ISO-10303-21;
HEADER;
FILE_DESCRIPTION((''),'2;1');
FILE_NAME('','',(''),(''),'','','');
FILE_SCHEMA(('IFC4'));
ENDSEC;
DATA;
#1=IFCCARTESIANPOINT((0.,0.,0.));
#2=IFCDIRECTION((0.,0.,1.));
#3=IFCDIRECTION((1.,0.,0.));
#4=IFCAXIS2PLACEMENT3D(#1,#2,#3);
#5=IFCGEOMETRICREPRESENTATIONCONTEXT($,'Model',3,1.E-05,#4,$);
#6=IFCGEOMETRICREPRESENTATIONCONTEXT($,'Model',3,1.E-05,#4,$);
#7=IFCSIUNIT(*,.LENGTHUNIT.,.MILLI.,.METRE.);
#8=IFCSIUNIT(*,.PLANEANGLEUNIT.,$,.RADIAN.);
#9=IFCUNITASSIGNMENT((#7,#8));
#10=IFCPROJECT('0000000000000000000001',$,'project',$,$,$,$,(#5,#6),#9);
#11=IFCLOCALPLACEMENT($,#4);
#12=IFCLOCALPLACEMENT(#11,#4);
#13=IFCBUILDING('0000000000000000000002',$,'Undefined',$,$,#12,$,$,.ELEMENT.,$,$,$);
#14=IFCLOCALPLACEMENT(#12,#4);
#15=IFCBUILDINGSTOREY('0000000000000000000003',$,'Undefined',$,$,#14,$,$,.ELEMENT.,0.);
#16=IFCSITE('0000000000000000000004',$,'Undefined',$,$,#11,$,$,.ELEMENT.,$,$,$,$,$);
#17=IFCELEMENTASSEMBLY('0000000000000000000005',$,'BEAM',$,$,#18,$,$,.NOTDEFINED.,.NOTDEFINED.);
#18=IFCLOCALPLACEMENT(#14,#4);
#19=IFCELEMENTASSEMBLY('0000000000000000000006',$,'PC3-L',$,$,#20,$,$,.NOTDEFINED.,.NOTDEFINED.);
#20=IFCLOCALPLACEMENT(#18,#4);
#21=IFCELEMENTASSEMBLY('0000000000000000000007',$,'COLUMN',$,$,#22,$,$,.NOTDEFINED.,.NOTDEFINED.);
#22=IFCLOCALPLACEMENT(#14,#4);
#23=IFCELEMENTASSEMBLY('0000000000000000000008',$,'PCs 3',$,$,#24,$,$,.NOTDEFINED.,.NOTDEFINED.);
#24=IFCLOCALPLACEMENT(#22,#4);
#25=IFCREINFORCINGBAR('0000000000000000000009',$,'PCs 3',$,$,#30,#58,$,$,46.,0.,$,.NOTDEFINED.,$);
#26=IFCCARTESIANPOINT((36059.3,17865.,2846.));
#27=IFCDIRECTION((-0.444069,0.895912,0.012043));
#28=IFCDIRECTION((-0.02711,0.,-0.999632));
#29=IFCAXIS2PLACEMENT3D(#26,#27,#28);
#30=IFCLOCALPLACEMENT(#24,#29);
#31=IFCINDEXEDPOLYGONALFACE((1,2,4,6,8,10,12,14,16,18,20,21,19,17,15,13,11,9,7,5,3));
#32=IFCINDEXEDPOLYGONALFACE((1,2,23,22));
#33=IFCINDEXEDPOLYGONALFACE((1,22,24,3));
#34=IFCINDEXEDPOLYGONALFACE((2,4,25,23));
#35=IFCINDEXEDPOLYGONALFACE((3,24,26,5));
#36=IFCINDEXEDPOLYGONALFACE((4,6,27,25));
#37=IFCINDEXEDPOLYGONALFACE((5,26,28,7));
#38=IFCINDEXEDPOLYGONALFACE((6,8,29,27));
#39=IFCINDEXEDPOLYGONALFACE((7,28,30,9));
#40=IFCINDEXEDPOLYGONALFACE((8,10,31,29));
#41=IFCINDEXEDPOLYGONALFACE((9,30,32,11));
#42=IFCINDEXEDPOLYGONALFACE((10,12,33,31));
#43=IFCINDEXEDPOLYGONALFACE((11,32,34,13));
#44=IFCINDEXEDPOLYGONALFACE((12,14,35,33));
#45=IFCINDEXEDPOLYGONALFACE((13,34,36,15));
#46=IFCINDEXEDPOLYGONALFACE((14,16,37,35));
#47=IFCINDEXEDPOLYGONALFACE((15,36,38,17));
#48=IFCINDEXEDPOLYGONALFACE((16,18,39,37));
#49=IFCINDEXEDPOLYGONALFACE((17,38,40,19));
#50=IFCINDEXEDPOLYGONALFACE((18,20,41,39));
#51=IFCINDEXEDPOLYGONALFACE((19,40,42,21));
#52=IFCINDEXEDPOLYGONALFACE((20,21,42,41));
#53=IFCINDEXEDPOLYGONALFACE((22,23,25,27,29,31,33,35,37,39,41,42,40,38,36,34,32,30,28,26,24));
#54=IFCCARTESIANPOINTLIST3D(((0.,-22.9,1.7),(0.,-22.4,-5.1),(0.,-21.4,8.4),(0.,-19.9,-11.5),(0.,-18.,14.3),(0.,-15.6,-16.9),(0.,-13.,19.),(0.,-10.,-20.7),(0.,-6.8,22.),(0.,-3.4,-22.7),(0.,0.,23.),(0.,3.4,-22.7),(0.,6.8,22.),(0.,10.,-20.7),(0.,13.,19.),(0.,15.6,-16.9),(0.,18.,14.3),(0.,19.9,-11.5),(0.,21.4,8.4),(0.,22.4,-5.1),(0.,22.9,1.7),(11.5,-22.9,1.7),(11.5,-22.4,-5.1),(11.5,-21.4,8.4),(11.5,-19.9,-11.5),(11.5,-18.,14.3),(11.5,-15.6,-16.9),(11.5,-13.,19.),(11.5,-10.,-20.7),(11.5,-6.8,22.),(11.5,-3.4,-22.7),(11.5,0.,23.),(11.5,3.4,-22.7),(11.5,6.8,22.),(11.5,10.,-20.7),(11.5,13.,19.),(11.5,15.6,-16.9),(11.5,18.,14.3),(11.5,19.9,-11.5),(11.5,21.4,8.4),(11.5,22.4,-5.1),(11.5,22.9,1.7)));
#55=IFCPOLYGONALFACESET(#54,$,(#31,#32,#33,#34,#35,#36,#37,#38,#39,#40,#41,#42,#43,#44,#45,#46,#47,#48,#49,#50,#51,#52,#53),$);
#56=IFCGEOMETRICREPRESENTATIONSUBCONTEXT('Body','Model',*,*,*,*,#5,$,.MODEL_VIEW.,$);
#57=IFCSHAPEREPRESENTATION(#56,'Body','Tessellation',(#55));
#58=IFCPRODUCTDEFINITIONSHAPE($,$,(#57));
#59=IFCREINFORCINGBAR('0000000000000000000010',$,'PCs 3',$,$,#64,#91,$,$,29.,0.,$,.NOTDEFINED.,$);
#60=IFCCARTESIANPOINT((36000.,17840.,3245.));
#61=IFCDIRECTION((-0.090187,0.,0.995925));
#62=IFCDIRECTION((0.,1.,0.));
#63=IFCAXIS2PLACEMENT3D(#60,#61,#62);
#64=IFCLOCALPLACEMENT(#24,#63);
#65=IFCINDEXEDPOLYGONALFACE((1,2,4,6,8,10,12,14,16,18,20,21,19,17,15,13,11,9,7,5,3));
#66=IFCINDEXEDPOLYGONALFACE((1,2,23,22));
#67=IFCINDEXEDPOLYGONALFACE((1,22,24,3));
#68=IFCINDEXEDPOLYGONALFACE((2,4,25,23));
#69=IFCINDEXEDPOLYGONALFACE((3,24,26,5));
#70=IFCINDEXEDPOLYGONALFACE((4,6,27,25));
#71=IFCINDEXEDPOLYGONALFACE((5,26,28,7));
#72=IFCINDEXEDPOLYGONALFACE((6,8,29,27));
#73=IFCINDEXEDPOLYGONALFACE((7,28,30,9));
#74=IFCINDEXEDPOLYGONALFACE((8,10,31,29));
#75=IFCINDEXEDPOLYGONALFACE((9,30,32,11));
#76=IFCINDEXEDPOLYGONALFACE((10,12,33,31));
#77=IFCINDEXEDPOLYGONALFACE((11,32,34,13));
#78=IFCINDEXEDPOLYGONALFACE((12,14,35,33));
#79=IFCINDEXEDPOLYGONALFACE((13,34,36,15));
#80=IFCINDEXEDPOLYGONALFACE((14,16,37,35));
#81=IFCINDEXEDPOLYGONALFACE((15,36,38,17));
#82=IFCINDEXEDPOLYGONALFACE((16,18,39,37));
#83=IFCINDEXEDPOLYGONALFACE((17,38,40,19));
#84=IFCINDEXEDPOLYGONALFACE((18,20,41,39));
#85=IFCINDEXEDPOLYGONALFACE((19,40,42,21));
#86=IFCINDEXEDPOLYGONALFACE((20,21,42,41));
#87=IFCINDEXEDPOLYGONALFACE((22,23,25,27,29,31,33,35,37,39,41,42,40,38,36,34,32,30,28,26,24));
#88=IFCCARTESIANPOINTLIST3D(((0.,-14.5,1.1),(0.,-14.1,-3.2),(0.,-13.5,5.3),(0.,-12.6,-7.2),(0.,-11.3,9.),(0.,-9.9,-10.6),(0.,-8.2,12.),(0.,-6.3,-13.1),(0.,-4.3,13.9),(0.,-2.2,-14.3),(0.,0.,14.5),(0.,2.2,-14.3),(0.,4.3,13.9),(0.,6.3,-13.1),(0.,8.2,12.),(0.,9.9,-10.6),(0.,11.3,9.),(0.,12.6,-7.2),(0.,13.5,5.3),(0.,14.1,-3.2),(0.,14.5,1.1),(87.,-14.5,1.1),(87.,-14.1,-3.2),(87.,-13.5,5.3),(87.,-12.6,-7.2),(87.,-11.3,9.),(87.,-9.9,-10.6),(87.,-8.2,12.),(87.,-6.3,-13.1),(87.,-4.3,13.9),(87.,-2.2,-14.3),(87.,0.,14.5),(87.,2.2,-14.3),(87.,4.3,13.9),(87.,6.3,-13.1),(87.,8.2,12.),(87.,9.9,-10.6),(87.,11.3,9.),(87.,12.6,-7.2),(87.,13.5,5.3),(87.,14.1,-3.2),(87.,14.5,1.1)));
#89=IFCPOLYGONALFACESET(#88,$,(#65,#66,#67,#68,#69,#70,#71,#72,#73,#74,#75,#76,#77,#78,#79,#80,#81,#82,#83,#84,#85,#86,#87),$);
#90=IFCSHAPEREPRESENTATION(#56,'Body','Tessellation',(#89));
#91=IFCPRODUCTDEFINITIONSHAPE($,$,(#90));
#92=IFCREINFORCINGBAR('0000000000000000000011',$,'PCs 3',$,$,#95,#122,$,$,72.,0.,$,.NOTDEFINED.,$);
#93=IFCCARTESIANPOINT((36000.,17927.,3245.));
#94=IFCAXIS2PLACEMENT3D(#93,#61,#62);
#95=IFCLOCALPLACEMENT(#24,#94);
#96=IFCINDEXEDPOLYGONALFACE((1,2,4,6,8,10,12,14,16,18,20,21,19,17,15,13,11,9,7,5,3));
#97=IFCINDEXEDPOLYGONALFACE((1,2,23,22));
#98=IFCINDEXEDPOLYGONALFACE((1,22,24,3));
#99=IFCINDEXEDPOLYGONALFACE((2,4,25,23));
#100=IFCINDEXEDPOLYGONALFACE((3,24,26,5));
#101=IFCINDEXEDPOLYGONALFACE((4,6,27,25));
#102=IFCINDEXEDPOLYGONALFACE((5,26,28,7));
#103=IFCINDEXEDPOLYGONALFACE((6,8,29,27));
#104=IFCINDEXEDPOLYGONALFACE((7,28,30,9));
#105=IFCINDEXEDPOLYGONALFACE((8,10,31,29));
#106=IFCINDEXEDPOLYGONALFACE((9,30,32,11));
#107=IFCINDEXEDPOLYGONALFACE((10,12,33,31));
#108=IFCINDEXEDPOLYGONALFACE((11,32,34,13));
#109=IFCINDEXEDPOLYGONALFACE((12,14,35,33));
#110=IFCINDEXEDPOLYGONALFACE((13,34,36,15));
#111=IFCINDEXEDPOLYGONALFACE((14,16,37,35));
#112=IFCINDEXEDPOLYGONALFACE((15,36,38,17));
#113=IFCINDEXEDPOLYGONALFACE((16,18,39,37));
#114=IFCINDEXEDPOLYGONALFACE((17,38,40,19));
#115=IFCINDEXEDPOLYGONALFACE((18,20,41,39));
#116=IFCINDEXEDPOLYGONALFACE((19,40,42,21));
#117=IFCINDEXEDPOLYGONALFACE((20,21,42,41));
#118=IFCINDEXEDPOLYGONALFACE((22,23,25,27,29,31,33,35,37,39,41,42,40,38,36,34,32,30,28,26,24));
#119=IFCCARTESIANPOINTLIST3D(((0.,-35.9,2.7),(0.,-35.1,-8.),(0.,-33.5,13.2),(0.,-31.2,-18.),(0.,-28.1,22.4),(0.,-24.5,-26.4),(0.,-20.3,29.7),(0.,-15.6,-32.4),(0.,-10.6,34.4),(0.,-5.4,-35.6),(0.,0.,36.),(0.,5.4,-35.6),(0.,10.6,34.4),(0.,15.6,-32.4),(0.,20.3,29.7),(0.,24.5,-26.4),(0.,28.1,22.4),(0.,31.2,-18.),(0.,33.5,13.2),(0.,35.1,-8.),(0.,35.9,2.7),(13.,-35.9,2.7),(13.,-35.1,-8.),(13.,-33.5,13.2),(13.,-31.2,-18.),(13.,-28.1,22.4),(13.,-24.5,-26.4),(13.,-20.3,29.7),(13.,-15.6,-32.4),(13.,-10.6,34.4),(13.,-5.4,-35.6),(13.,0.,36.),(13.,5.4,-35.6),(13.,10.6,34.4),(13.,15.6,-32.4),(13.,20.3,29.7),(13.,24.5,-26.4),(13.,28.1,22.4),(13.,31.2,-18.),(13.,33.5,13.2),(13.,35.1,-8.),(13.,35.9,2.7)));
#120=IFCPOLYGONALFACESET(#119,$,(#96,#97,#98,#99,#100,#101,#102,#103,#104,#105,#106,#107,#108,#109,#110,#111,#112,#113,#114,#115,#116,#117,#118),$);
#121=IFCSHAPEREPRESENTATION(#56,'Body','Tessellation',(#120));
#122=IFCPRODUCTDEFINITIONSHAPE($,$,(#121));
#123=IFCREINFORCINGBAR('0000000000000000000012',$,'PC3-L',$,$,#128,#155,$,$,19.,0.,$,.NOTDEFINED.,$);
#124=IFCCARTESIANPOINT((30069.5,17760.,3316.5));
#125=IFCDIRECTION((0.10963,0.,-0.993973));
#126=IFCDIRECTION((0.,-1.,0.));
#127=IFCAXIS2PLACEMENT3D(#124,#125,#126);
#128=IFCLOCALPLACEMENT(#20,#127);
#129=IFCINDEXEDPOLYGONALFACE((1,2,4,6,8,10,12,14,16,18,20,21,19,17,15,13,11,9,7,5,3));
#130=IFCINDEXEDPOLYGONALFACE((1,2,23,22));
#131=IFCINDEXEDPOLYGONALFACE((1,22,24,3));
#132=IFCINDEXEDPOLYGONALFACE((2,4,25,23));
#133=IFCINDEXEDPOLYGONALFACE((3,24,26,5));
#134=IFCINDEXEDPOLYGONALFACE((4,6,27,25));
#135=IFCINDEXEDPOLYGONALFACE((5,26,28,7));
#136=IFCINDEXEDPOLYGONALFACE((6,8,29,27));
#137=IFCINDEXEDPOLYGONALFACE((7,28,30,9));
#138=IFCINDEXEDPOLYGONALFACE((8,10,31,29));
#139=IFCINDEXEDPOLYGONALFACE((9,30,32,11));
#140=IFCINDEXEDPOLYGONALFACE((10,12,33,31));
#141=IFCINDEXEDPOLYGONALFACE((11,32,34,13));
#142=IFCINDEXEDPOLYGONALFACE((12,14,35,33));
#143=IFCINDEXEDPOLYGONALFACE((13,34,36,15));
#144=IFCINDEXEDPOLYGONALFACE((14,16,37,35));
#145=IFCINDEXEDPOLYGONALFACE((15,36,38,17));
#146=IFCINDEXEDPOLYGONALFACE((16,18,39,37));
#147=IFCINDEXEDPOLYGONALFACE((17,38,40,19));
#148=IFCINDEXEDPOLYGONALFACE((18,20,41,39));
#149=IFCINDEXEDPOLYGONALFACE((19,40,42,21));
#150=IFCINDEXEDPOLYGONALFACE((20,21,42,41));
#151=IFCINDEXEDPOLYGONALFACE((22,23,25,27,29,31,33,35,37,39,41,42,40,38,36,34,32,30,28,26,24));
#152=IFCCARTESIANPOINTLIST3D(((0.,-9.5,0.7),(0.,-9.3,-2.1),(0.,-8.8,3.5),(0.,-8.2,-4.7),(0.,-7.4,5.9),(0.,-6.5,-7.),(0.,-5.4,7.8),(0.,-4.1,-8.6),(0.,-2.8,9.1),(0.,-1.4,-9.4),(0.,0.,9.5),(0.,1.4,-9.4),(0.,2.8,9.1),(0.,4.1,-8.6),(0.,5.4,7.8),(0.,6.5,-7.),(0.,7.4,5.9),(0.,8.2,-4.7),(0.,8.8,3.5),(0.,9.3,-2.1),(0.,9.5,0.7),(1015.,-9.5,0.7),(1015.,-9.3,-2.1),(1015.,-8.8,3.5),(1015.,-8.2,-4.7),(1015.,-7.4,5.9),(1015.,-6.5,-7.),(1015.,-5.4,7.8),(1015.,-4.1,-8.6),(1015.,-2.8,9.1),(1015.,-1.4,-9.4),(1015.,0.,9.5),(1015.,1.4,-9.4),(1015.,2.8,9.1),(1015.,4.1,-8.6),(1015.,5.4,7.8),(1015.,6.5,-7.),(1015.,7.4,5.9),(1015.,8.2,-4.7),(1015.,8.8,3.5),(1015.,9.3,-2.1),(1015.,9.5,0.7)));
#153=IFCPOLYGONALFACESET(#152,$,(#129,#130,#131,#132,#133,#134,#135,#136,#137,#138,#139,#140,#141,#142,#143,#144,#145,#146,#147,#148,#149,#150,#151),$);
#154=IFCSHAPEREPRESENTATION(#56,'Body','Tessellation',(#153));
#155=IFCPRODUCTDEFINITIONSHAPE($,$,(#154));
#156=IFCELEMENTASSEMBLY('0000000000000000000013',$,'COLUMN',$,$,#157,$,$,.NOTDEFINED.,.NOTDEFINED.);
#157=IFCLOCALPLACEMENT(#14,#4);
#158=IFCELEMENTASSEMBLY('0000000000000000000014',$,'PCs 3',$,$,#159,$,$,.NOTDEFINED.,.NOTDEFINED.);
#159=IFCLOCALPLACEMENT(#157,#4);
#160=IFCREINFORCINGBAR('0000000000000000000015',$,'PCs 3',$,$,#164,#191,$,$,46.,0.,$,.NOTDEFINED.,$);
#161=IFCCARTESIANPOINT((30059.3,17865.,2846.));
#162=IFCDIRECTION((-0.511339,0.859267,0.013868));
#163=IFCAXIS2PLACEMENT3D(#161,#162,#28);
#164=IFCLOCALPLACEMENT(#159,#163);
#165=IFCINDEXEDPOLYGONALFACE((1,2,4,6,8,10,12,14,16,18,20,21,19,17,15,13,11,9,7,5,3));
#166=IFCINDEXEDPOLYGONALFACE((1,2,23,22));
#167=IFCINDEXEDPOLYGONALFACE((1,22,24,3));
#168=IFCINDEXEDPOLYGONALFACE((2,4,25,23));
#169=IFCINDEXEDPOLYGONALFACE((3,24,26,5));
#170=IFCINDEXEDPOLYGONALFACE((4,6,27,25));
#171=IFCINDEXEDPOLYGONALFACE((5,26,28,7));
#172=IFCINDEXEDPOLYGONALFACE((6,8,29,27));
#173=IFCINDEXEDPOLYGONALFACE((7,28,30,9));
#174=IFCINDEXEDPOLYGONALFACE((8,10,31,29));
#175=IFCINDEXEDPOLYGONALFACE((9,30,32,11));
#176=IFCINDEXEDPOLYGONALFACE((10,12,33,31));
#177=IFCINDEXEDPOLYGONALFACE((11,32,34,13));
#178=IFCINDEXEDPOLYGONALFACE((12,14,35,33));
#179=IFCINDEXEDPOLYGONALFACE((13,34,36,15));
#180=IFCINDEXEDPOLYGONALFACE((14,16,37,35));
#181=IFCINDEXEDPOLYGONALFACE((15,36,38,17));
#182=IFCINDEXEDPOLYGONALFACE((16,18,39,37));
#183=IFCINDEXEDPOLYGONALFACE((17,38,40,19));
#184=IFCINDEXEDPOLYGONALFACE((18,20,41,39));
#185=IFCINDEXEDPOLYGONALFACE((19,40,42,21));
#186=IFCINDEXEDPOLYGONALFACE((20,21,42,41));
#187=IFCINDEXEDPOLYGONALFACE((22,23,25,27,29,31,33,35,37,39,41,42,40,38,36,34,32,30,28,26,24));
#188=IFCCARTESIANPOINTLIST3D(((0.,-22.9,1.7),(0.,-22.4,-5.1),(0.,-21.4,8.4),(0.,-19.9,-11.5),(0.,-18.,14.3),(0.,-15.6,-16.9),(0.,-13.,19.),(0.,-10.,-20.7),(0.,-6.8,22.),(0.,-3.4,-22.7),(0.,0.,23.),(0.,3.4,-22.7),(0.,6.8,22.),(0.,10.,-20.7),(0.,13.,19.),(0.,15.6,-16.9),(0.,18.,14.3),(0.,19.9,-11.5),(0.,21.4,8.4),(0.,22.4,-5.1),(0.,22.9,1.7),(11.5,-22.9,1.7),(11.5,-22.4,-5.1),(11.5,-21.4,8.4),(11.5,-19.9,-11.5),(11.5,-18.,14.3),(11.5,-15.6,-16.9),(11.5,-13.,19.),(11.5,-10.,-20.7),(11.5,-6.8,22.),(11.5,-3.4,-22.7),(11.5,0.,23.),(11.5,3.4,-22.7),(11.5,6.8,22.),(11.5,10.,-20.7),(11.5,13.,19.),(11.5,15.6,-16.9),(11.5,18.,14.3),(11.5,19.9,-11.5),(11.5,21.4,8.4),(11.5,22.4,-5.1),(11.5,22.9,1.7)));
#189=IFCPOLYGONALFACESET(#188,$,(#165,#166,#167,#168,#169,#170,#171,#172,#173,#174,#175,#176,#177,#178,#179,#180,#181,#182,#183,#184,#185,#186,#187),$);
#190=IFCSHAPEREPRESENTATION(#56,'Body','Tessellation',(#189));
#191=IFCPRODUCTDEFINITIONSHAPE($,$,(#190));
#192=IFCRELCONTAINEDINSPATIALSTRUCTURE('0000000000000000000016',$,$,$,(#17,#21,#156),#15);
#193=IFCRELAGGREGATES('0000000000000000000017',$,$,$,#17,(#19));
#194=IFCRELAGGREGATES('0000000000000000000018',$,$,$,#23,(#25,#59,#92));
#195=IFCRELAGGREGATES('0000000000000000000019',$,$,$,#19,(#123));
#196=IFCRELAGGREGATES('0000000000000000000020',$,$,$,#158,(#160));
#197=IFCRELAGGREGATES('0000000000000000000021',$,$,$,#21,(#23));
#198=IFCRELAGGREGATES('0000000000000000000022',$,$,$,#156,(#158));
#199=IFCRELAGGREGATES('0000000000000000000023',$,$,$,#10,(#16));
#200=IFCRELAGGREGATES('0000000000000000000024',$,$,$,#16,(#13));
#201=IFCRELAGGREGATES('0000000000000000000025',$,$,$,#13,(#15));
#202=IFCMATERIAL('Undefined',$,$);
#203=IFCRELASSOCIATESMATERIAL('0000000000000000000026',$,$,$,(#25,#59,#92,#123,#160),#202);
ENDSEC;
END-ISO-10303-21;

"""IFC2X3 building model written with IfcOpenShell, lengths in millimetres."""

from ifc_helpers import new_model, entity, si_unit, frame, origin_with_axes, place, context, subcontext, project, spatial, source, transform, mapped, material, element, aggregate, save


model = new_model("IFC2X3")

# Units and contexts
model_context_1 = context("Model", 3, precision=1e-05, world=origin_with_axes())
model_context_2 = context("Model", 3, precision=1e-05, world=origin_with_axes())
body_context = subcontext(model_context_1, "Body", "Model", "MODEL_VIEW")
ifc_project = project(units=[si_unit("LENGTHUNIT", "METRE", prefix="MILLI"), si_unit("PLANEANGLEUNIT", "RADIAN")], contexts=[model_context_1, model_context_2])

# Site, building, storey
site_placement = place(None, origin_with_axes())
site = spatial("IfcSite", under=ifc_project, at=site_placement, Name="Undefined", CompositionType="ELEMENT")
building_placement = place(site_placement, origin_with_axes())
building = spatial("IfcBuilding", under=site, at=building_placement, Name="Undefined", CompositionType="ELEMENT")
storey_placement = place(building_placement, origin_with_axes())
storey = spatial("IfcBuildingStorey", under=building, at=storey_placement, Name="Undefined", CompositionType="ELEMENT", Elevation=0.0)

# Element assemblies
assembly_1_placement = place(storey_placement, origin_with_axes())
assembly_1 = element("IfcElementAssembly", 1, at=assembly_1_placement, inside=storey, Name="BEAM", AssemblyPlace="NOTDEFINED", PredefinedType="NOTDEFINED")
assembly_2_placement = place(assembly_1_placement, origin_with_axes())
assembly_2 = element("IfcElementAssembly", 2, at=assembly_2_placement, Name="PC3-L", AssemblyPlace="NOTDEFINED", PredefinedType="NOTDEFINED")
aggregate(assembly_1, [assembly_2])

# Element assemblies
assembly_3_placement = place(storey_placement, origin_with_axes())
assembly_3 = element("IfcElementAssembly", 3, at=assembly_3_placement, inside=storey, Name="COLUMN", AssemblyPlace="NOTDEFINED", PredefinedType="NOTDEFINED")
assembly_4_placement = place(assembly_3_placement, origin_with_axes())
assembly_4 = element("IfcElementAssembly", 4, at=assembly_4_placement, Name="PCs 3", AssemblyPlace="NOTDEFINED", PredefinedType="NOTDEFINED")

# Reinforcing bars
ifc_material_1 = material(Name="Undefined")
shared_shape_1 = source(origin_with_axes(), body_context, "Body", "AdvancedSweptSolid", [
    entity("IfcSweptDiskSolid", entity("IfcTrimmedCurve", entity("IfcLine", entity("IfcCartesianPoint", [0.0, 0.0, 0.0]), entity("IfcVector", entity("IfcDirection", [1.0, 0.0, 0.0]), 1.0)), [entity("IfcParameterValue", 0.0)], [entity("IfcParameterValue", 11.5)], True, "PARAMETER"), 23.0, None, 0.0, 11.5),
])
reinforcing_bar_1_placement = place(assembly_4_placement, frame((36059.3, 17865.0, 2846.0), z_axis=(-0.444069, 0.895912, 0.012043), x_axis=(-0.02711, 0.0, -0.999632)))
reinforcing_bar_1 = element("IfcReinforcingBar", 5, at=reinforcing_bar_1_placement, material=ifc_material_1, Name="PCs 3", BarRole="NOTDEFINED", CrossSectionArea=0.0, NominalDiameter=46.0, context=body_context, shape_type="MappedRepresentation", body=[
    mapped(shared_shape_1, transform((0.0, 0.0, 0.0))),
])
shared_shape_2 = source(origin_with_axes(), body_context, "Body", "AdvancedSweptSolid", [
    entity("IfcSweptDiskSolid", entity("IfcTrimmedCurve", entity("IfcLine", entity("IfcCartesianPoint", [0.0, 0.0, 0.0]), entity("IfcVector", entity("IfcDirection", [1.0, 0.0, 0.0]), 1.0)), [entity("IfcParameterValue", 0.0)], [entity("IfcParameterValue", 87.0)], True, "PARAMETER"), 14.5, None, 0.0, 87.0),
])
reinforcing_bar_2_placement = place(assembly_4_placement, frame((36000.0, 17840.0, 3245.0), z_axis=(-0.090187, 0.0, 0.995925), x_axis=(0.0, 1.0, 0.0)))
reinforcing_bar_2 = element("IfcReinforcingBar", 6, at=reinforcing_bar_2_placement, material=ifc_material_1, Name="PCs 3", BarRole="NOTDEFINED", CrossSectionArea=0.0, NominalDiameter=29.0, context=body_context, shape_type="MappedRepresentation", body=[
    mapped(shared_shape_2, transform((0.0, 0.0, 0.0))),
])
shared_shape_3 = source(origin_with_axes(), body_context, "Body", "AdvancedSweptSolid", [
    entity("IfcSweptDiskSolid", entity("IfcTrimmedCurve", entity("IfcLine", entity("IfcCartesianPoint", [0.0, 0.0, 0.0]), entity("IfcVector", entity("IfcDirection", [1.0, 0.0, 0.0]), 1.0)), [entity("IfcParameterValue", 0.0)], [entity("IfcParameterValue", 13.0)], True, "PARAMETER"), 36.0, None, 0.0, 13.0),
])
reinforcing_bar_3_placement = place(assembly_4_placement, frame((36000.0, 17927.0, 3245.0), z_axis=(-0.090187, 0.0, 0.995925), x_axis=(0.0, 1.0, 0.0)))
reinforcing_bar_3 = element("IfcReinforcingBar", 7, at=reinforcing_bar_3_placement, material=ifc_material_1, Name="PCs 3", BarRole="NOTDEFINED", CrossSectionArea=0.0, NominalDiameter=72.0, context=body_context, shape_type="MappedRepresentation", body=[
    mapped(shared_shape_3, transform((0.0, 0.0, 0.0))),
])
aggregate(assembly_4, [reinforcing_bar_1, reinforcing_bar_2, reinforcing_bar_3])
shared_shape_4 = source(origin_with_axes(), body_context, "Body", "AdvancedSweptSolid", [
    entity("IfcSweptDiskSolid", entity("IfcTrimmedCurve", entity("IfcLine", entity("IfcCartesianPoint", [0.0, 0.0, 0.0]), entity("IfcVector", entity("IfcDirection", [1.0, 0.0, 0.0]), 1.0)), [entity("IfcParameterValue", 0.0)], [entity("IfcParameterValue", 1015.0)], True, "PARAMETER"), 9.5, None, 0.0, 1015.0),
])
reinforcing_bar_4_placement = place(assembly_2_placement, frame((30069.5, 17760.0, 3316.5), z_axis=(0.10963, 0.0, -0.993973), x_axis=(0.0, -1.0, 0.0)))
reinforcing_bar_4 = element("IfcReinforcingBar", 8, at=reinforcing_bar_4_placement, material=ifc_material_1, Name="PC3-L", BarRole="NOTDEFINED", CrossSectionArea=0.0, NominalDiameter=19.0, context=body_context, shape_type="MappedRepresentation", body=[
    mapped(shared_shape_4, transform((0.0, 0.0, 0.0))),
])
aggregate(assembly_2, [reinforcing_bar_4])

# Element assemblies, reinforcing bar
assembly_5_placement = place(storey_placement, origin_with_axes())
assembly_5 = element("IfcElementAssembly", 9, at=assembly_5_placement, inside=storey, Name="COLUMN", AssemblyPlace="NOTDEFINED", PredefinedType="NOTDEFINED")
assembly_6_placement = place(assembly_5_placement, origin_with_axes())
assembly_6 = element("IfcElementAssembly", 10, at=assembly_6_placement, Name="PCs 3", AssemblyPlace="NOTDEFINED", PredefinedType="NOTDEFINED")
shared_shape_5 = source(origin_with_axes(), body_context, "Body", "AdvancedSweptSolid", [
    entity("IfcSweptDiskSolid", entity("IfcTrimmedCurve", entity("IfcLine", entity("IfcCartesianPoint", [0.0, 0.0, 0.0]), entity("IfcVector", entity("IfcDirection", [1.0, 0.0, 0.0]), 1.0)), [entity("IfcParameterValue", 0.0)], [entity("IfcParameterValue", 11.5)], True, "PARAMETER"), 23.0, None, 0.0, 11.5),
])
reinforcing_bar_5_placement = place(assembly_6_placement, frame((30059.3, 17865.0, 2846.0), z_axis=(-0.511339, 0.859267, 0.013868), x_axis=(-0.02711, 0.0, -0.999632)))
reinforcing_bar_5 = element("IfcReinforcingBar", 11, at=reinforcing_bar_5_placement, material=ifc_material_1, Name="PCs 3", BarRole="NOTDEFINED", CrossSectionArea=0.0, NominalDiameter=46.0, context=body_context, shape_type="MappedRepresentation", body=[
    mapped(shared_shape_5, transform((0.0, 0.0, 0.0))),
])
aggregate(assembly_6, [reinforcing_bar_5])

aggregate(assembly_3, [assembly_4])
aggregate(assembly_5, [assembly_6])

save(model, "model.ifc")
